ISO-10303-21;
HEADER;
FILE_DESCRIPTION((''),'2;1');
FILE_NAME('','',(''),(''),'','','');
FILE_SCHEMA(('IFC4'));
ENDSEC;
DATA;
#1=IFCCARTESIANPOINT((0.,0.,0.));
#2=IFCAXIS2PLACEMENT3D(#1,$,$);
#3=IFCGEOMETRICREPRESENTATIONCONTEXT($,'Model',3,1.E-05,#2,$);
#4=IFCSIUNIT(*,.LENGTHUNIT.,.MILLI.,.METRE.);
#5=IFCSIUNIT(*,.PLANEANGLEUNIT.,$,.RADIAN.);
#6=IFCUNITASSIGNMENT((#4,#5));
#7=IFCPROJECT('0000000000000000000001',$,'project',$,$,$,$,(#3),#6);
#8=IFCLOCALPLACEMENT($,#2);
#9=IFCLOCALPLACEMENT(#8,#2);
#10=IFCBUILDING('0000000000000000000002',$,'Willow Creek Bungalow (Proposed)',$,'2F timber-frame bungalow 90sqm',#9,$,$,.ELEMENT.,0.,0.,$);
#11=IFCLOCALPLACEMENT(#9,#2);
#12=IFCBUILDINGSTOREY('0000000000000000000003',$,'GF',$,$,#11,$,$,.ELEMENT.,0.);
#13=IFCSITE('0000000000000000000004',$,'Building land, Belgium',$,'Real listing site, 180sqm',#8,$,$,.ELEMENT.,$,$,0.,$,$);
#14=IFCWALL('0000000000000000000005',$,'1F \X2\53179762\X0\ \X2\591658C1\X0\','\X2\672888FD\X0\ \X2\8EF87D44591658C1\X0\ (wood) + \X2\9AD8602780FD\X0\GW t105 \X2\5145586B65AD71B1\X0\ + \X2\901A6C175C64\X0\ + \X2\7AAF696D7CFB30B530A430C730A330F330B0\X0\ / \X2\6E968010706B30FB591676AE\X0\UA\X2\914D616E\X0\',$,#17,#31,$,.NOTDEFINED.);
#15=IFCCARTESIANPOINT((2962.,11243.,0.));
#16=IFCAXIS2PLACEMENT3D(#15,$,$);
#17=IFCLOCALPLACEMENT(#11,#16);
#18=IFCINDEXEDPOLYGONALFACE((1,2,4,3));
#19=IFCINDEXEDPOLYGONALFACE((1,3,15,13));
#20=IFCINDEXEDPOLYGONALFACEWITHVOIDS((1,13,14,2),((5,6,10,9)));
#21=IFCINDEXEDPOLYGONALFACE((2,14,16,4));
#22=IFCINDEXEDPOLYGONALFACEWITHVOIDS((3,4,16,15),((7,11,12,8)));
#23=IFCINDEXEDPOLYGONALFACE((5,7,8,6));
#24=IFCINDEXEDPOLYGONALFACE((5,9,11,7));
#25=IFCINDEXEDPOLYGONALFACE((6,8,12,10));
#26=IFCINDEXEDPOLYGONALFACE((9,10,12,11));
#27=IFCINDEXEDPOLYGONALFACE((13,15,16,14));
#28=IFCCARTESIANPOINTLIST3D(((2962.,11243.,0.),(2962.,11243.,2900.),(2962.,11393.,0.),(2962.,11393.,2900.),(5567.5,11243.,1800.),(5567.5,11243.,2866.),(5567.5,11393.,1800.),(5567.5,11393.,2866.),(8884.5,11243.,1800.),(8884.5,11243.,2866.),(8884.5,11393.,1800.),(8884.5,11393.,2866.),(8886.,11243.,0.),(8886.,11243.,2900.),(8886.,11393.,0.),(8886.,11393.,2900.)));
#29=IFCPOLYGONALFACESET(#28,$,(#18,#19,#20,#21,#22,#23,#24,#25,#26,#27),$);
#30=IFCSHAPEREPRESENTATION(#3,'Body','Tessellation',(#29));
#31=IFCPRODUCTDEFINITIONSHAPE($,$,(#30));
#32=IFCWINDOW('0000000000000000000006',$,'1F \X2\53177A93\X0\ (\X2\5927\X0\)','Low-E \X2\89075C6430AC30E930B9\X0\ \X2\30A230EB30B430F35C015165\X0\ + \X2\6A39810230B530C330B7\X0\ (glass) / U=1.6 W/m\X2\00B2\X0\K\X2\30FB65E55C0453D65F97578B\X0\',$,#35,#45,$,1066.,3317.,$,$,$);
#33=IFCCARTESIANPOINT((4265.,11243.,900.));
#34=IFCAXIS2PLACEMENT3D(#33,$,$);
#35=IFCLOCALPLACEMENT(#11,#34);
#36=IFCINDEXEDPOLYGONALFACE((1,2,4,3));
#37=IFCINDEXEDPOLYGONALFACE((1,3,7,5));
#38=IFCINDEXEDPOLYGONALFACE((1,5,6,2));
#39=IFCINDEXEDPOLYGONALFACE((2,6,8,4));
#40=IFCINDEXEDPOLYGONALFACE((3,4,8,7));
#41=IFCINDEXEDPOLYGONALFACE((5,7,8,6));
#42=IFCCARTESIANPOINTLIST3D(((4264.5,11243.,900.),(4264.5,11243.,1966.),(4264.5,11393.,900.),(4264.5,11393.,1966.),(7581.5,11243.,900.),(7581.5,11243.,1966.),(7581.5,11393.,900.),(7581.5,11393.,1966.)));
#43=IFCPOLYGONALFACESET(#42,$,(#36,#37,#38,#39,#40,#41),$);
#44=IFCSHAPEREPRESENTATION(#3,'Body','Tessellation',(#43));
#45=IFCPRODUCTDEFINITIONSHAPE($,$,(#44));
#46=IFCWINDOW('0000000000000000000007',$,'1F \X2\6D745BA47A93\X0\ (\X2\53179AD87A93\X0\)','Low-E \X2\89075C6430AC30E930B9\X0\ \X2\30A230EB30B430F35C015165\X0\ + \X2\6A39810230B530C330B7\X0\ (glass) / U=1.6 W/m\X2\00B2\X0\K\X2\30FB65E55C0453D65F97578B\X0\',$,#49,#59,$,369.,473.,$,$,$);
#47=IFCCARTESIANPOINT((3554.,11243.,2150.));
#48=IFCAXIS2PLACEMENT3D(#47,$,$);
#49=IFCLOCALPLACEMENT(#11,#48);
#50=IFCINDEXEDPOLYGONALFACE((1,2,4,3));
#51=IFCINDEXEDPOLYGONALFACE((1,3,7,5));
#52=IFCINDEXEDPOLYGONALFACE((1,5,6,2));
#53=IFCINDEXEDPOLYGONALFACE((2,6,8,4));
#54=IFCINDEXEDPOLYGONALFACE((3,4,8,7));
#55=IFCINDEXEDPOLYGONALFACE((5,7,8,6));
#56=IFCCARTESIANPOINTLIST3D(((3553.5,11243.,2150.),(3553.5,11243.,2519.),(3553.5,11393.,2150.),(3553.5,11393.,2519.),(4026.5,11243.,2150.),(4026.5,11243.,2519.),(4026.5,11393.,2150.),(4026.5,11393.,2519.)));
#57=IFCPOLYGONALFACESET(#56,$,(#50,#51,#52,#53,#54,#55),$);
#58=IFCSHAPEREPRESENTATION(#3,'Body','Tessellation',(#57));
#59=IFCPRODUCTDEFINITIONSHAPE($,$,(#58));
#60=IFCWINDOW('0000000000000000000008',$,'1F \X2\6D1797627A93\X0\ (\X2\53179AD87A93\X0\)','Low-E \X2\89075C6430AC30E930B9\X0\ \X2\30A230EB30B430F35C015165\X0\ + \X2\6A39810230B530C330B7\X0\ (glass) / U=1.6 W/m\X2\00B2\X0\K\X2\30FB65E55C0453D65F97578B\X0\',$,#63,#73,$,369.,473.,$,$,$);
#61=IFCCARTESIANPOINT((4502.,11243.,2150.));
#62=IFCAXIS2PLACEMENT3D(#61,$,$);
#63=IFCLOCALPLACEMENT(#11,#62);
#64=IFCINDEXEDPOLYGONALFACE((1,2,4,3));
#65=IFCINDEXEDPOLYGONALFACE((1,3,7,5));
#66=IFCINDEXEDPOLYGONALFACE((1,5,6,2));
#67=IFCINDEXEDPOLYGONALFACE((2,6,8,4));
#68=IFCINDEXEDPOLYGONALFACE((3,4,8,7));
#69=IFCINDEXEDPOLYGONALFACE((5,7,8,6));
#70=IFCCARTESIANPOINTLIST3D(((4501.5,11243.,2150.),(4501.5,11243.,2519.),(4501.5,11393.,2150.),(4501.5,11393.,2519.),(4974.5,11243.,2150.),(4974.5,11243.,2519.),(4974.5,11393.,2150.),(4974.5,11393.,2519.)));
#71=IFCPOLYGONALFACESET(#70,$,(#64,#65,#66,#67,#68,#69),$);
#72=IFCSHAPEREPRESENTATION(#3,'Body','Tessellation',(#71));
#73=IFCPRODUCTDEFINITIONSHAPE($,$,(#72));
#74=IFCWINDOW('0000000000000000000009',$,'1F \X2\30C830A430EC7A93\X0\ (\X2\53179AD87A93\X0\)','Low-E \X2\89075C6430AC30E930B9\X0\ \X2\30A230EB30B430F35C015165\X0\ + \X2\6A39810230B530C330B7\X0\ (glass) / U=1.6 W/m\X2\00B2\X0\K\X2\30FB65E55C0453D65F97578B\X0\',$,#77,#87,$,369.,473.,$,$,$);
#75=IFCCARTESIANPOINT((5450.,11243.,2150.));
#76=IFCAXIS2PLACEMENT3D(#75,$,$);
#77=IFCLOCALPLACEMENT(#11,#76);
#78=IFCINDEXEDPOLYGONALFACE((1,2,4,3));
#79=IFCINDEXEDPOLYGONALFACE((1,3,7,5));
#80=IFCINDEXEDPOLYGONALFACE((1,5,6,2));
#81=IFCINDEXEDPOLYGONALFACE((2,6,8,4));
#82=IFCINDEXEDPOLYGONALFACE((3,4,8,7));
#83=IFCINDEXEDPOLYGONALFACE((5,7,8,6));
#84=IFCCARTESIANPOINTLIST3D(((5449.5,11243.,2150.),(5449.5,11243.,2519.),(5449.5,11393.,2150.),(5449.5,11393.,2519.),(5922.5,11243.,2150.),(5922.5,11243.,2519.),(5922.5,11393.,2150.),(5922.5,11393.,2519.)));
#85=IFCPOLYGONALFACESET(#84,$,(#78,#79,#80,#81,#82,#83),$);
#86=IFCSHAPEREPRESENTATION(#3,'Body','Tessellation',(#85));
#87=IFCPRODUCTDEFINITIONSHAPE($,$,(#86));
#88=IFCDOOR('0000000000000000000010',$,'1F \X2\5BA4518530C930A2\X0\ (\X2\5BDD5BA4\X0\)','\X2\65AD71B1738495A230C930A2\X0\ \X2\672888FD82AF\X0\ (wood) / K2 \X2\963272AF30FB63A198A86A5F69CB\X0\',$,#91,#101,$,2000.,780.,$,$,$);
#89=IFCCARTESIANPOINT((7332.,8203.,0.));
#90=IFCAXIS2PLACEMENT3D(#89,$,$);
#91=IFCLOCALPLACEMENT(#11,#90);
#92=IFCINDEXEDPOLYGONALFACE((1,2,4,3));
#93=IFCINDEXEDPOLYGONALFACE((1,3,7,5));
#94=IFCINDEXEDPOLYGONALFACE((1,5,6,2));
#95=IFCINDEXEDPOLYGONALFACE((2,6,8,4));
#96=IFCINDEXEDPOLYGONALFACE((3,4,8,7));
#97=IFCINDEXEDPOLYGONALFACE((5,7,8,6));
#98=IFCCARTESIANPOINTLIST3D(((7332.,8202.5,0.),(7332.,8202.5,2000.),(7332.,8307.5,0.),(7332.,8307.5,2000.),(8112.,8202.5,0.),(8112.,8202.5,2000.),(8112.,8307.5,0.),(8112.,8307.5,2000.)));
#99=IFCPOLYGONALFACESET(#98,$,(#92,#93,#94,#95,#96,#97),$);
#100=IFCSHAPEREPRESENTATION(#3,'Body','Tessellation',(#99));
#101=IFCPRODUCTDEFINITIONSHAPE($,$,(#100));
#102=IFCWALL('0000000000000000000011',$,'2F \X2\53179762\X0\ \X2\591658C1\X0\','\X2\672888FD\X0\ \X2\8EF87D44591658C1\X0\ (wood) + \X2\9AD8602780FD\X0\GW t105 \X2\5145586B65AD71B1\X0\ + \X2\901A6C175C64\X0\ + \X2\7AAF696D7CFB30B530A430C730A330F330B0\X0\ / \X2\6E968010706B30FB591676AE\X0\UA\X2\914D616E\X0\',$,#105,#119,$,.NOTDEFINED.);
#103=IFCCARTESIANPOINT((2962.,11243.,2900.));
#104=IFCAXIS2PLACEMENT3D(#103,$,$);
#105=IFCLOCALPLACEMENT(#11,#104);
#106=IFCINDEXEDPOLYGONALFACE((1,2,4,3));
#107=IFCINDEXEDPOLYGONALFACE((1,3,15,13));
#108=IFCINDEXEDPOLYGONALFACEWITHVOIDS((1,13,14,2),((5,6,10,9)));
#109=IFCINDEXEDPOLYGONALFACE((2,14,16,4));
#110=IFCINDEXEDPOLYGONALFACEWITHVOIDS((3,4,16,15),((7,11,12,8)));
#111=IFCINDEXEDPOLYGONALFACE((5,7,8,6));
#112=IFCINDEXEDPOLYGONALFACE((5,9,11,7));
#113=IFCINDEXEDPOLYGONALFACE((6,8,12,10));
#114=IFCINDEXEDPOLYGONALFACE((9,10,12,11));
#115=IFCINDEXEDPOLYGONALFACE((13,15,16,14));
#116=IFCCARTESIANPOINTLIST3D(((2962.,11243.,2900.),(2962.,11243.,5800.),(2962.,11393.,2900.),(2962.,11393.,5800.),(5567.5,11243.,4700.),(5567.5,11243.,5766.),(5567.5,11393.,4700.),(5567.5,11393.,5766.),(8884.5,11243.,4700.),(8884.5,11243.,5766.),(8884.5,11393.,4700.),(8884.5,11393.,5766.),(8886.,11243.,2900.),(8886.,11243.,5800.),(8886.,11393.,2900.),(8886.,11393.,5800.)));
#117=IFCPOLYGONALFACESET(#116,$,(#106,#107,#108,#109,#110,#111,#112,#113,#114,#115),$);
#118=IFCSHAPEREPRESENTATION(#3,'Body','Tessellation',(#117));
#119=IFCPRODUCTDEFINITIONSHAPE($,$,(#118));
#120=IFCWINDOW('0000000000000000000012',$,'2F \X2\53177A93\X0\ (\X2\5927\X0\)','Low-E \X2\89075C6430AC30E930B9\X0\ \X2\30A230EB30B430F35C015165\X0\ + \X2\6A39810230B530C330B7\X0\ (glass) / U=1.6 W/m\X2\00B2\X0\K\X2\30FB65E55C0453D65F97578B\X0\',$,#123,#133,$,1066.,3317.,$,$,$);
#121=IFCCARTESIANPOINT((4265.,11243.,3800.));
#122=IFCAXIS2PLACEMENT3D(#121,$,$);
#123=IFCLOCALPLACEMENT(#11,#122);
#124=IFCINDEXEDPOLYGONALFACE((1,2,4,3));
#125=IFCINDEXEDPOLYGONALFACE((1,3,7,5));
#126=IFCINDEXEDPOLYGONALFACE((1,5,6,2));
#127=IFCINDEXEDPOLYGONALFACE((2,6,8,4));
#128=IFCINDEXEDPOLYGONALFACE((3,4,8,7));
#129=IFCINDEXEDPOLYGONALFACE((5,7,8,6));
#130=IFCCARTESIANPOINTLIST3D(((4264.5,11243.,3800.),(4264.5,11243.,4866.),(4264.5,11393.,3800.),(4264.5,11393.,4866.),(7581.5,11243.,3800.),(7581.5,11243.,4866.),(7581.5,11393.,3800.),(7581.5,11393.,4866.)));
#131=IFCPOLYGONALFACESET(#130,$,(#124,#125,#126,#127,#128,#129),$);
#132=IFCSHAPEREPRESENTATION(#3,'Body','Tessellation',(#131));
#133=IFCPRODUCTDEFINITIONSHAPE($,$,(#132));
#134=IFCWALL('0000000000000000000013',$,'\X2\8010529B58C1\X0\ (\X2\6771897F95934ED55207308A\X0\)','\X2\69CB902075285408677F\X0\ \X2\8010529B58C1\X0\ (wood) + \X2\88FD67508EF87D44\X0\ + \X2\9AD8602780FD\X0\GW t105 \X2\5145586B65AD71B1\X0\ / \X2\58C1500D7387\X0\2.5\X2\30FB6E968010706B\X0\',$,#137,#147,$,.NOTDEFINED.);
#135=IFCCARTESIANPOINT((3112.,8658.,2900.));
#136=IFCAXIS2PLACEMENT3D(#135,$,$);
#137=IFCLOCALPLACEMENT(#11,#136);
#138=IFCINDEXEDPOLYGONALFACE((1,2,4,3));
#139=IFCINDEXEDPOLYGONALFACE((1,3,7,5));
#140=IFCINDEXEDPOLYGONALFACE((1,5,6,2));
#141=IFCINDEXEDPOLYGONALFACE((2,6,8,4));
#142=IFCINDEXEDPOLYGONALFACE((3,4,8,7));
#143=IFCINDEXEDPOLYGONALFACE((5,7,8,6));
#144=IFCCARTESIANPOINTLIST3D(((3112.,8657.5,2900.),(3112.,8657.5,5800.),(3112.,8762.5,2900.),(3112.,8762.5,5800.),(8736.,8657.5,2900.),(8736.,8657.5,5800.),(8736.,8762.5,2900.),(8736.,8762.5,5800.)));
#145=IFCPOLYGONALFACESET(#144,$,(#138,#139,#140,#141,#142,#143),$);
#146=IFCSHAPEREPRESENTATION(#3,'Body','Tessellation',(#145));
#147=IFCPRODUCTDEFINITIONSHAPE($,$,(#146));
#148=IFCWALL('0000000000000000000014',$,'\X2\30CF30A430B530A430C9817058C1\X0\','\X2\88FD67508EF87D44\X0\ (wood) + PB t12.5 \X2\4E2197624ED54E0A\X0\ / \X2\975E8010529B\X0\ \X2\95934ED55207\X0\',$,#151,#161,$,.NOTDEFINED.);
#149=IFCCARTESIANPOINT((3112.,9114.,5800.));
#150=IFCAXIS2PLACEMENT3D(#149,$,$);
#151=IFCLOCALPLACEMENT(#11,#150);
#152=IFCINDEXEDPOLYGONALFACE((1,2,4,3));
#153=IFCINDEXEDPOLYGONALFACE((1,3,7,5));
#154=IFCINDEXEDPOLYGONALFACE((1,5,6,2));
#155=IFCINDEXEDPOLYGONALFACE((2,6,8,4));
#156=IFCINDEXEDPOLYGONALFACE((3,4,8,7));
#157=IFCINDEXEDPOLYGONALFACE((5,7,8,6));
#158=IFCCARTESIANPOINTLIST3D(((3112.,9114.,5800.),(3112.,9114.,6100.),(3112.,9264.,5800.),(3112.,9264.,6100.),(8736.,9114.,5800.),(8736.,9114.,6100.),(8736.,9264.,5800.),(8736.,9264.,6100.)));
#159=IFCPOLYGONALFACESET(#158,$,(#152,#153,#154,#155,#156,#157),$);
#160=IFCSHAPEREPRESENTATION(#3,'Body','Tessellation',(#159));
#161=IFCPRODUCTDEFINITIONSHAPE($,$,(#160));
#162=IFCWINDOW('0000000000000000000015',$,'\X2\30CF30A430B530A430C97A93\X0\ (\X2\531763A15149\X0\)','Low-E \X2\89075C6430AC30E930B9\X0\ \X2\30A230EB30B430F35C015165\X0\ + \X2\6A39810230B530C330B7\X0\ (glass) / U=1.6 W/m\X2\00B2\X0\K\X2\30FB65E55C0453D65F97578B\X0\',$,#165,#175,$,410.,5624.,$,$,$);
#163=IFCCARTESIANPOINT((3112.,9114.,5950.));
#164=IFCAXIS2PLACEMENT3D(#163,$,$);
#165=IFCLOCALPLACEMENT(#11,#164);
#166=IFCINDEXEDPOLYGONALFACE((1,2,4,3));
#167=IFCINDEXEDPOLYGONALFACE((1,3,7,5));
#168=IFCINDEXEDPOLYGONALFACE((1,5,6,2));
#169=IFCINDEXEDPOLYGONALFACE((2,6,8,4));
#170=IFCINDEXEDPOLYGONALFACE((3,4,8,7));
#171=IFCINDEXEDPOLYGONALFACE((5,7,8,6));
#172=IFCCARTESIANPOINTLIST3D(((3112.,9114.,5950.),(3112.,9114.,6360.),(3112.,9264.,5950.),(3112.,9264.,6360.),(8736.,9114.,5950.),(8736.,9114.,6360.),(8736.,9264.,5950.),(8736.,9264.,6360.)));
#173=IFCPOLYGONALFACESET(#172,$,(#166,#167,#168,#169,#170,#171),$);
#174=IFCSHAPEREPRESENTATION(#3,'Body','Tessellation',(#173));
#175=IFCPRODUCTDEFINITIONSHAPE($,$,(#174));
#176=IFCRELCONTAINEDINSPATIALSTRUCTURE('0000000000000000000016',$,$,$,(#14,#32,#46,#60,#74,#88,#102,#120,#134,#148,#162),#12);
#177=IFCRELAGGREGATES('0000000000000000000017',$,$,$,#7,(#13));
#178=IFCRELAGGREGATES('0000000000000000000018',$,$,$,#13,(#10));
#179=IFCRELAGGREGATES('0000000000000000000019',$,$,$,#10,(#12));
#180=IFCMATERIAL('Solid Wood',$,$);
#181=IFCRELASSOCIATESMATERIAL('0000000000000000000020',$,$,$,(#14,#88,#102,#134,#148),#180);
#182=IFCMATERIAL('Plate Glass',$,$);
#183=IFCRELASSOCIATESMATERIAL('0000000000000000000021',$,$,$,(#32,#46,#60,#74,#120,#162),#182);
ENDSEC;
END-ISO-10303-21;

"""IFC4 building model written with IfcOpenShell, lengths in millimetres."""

from ifc_helpers import new_model, si_unit, frame, frame_2d, origin, place, context, project, spatial, rectangle, extrude, material, element, fill, save


model = new_model("IFC4")

# Units and contexts
model_context = context("Model", 3, precision=1e-05, world=origin())
ifc_project = project(units=[si_unit("LENGTHUNIT", "METRE", prefix="MILLI"), si_unit("PLANEANGLEUNIT", "RADIAN")], contexts=[model_context])

# Site, building, storey
site_placement = place(None, origin())
site = spatial("IfcSite", under=ifc_project, at=site_placement, Name="Building land, Belgium", ObjectType="Real listing site, 180sqm", CompositionType="ELEMENT", RefElevation=0.0)
building_placement = place(site_placement, origin())
building = spatial("IfcBuilding", under=site, at=building_placement, Name="Willow Creek Bungalow (Proposed)", ObjectType="2F timber-frame bungalow 90sqm", CompositionType="ELEMENT", ElevationOfRefHeight=0.0, ElevationOfTerrain=0.0)
storey_placement = place(building_placement, origin())
storey = spatial("IfcBuildingStorey", under=building, at=storey_placement, Name="GF", CompositionType="ELEMENT", Elevation=0.0)

# Wall, openings, windows
ifc_material_1 = material(Name="Solid Wood")
wall_1_placement = place(storey_placement, frame((2962.0, 11243.0, 0.0)))
wall_1 = element("IfcWall", 1, at=wall_1_placement, inside=storey, material=ifc_material_1, Name="1F 北面 外壁", Description="木製 軸組外壁 (wood) + 高性能GW t105 充填断熱 + 通気層 + 窯業系サイディング / 準耐火・外皮UA配慮", PredefinedType="NOTDEFINED", context=model_context, shape_type="SweptSolid", body=[
    extrude(rectangle(XDim=5924.0, YDim=150.0, at=frame_2d((2962.0, 75.0))), frame((2962.0, 11243.0, 0.0)), (0.0, 0.0, 1.0), 2900.0),
])
opening_1_placement = place(storey_placement, frame((4265.0, 11243.0, 900.0)))
opening_1 = element("IfcOpeningElement", 2, at=opening_1_placement, cuts=wall_1, PredefinedType="NOTDEFINED", context=model_context, shape_type="SweptSolid", body=[
    extrude(rectangle(XDim=3317.0, YDim=150.0, at=frame_2d((1658.0, 75.0))), frame((4265.0, 11243.0, 900.0)), (0.0, 0.0, 1.0), 1066.0),
])
opening_2_placement = place(storey_placement, frame((3554.0, 11243.0, 2150.0)))
opening_2 = element("IfcOpeningElement", 3, at=opening_2_placement, cuts=wall_1, PredefinedType="NOTDEFINED", context=model_context, shape_type="SweptSolid", body=[
    extrude(rectangle(XDim=473.0, YDim=150.0, at=frame_2d((236.0, 75.0))), frame((3554.0, 11243.0, 2150.0)), (0.0, 0.0, 1.0), 369.0),
])
opening_3_placement = place(storey_placement, frame((4502.0, 11243.0, 2150.0)))
opening_3 = element("IfcOpeningElement", 4, at=opening_3_placement, cuts=wall_1, PredefinedType="NOTDEFINED", context=model_context, shape_type="SweptSolid", body=[
    extrude(rectangle(XDim=473.0, YDim=150.0, at=frame_2d((236.0, 75.0))), frame((4502.0, 11243.0, 2150.0)), (0.0, 0.0, 1.0), 369.0),
])
opening_4_placement = place(storey_placement, frame((5450.0, 11243.0, 2150.0)))
opening_4 = element("IfcOpeningElement", 5, at=opening_4_placement, cuts=wall_1, PredefinedType="NOTDEFINED", context=model_context, shape_type="SweptSolid", body=[
    extrude(rectangle(XDim=473.0, YDim=150.0, at=frame_2d((236.0, 75.0))), frame((5450.0, 11243.0, 2150.0)), (0.0, 0.0, 1.0), 369.0),
])
ifc_material_2 = material(Name="Plate Glass")
window_1_placement = place(storey_placement, frame((4265.0, 11243.0, 900.0)))
window_1 = element("IfcWindow", 6, at=window_1_placement, inside=storey, material=ifc_material_2, Name="1F 北窓 (大)", Description="Low-E 複層ガラス アルゴン封入 + 樹脂サッシ (glass) / U=1.6 W/m²K・日射取得型", OverallHeight=1066.0, OverallWidth=3317.0, context=model_context, shape_type="SweptSolid", body=[
    extrude(rectangle(XDim=3317.0, YDim=150.0, at=frame_2d((1658.0, 75.0))), frame((4265.0, 11243.0, 900.0)), (0.0, 0.0, 1.0), 1066.0),
])
fill(opening_1, window_1)
window_2_placement = place(storey_placement, frame((3554.0, 11243.0, 2150.0)))
window_2 = element("IfcWindow", 7, at=window_2_placement, inside=storey, material=ifc_material_2, Name="1F 浴室窓 (北高窓)", Description="Low-E 複層ガラス アルゴン封入 + 樹脂サッシ (glass) / U=1.6 W/m²K・日射取得型", OverallHeight=369.0, OverallWidth=473.0, context=model_context, shape_type="SweptSolid", body=[
    extrude(rectangle(XDim=473.0, YDim=150.0, at=frame_2d((236.0, 75.0))), frame((3554.0, 11243.0, 2150.0)), (0.0, 0.0, 1.0), 369.0),
])
fill(opening_2, window_2)
window_3_placement = place(storey_placement, frame((4502.0, 11243.0, 2150.0)))
window_3 = element("IfcWindow", 8, at=window_3_placement, inside=storey, material=ifc_material_2, Name="1F 洗面窓 (北高窓)", Description="Low-E 複層ガラス アルゴン封入 + 樹脂サッシ (glass) / U=1.6 W/m²K・日射取得型", OverallHeight=369.0, OverallWidth=473.0, context=model_context, shape_type="SweptSolid", body=[
    extrude(rectangle(XDim=473.0, YDim=150.0, at=frame_2d((236.0, 75.0))), frame((4502.0, 11243.0, 2150.0)), (0.0, 0.0, 1.0), 369.0),
])
fill(opening_3, window_3)
window_4_placement = place(storey_placement, frame((5450.0, 11243.0, 2150.0)))
window_4 = element("IfcWindow", 9, at=window_4_placement, inside=storey, material=ifc_material_2, Name="1F トイレ窓 (北高窓)", Description="Low-E 複層ガラス アルゴン封入 + 樹脂サッシ (glass) / U=1.6 W/m²K・日射取得型", OverallHeight=369.0, OverallWidth=473.0, context=model_context, shape_type="SweptSolid", body=[
    extrude(rectangle(XDim=473.0, YDim=150.0, at=frame_2d((236.0, 75.0))), frame((5450.0, 11243.0, 2150.0)), (0.0, 0.0, 1.0), 369.0),
])
fill(opening_4, window_4)

# Door
door_1_placement = place(storey_placement, frame((7332.0, 8203.0, 0.0)))
element("IfcDoor", 10, at=door_1_placement, inside=storey, material=ifc_material_1, Name="1F 室内ドア (寝室)", Description="断熱玄関ドア 木製芯 (wood) / K2 防犯・採風機構", OverallHeight=2000.0, OverallWidth=780.0, context=model_context, shape_type="SweptSolid", body=[
    extrude(rectangle(XDim=780.0, YDim=105.0, at=frame_2d((390.0, 52.0))), frame((7332.0, 8203.0, 0.0)), (0.0, 0.0, 1.0), 2000.0),
])

# Wall, opening, window
wall_2_placement = place(storey_placement, frame((2962.0, 11243.0, 2900.0)))
wall_2 = element("IfcWall", 11, at=wall_2_placement, inside=storey, material=ifc_material_1, Name="2F 北面 外壁", Description="木製 軸組外壁 (wood) + 高性能GW t105 充填断熱 + 通気層 + 窯業系サイディング / 準耐火・外皮UA配慮", PredefinedType="NOTDEFINED", context=model_context, shape_type="SweptSolid", body=[
    extrude(rectangle(XDim=5924.0, YDim=150.0, at=frame_2d((2962.0, 75.0))), frame((2962.0, 11243.0, 2900.0)), (0.0, 0.0, 1.0), 2900.0),
])
opening_5_placement = place(storey_placement, frame((4265.0, 11243.0, 3800.0)))
opening_5 = element("IfcOpeningElement", 12, at=opening_5_placement, cuts=wall_2, PredefinedType="NOTDEFINED", context=model_context, shape_type="SweptSolid", body=[
    extrude(rectangle(XDim=3317.0, YDim=150.0, at=frame_2d((1658.0, 75.0))), frame((4265.0, 11243.0, 3800.0)), (0.0, 0.0, 1.0), 1066.0),
])
window_5_placement = place(storey_placement, frame((4265.0, 11243.0, 3800.0)))
window_5 = element("IfcWindow", 13, at=window_5_placement, inside=storey, material=ifc_material_2, Name="2F 北窓 (大)", Description="Low-E 複層ガラス アルゴン封入 + 樹脂サッシ (glass) / U=1.6 W/m²K・日射取得型", OverallHeight=1066.0, OverallWidth=3317.0, context=model_context, shape_type="SweptSolid", body=[
    extrude(rectangle(XDim=3317.0, YDim=150.0, at=frame_2d((1658.0, 75.0))), frame((4265.0, 11243.0, 3800.0)), (0.0, 0.0, 1.0), 1066.0),
])
fill(opening_5, window_5)

# Wall
wall_3_placement = place(storey_placement, frame((3112.0, 8658.0, 2900.0)))
element("IfcWall", 14, at=wall_3_placement, inside=storey, material=ifc_material_1, Name="耐力壁 (東西間仕切り)", Description="構造用合板 耐力壁 (wood) + 製材軸組 + 高性能GW t105 充填断熱 / 壁倍率2.5・準耐火", PredefinedType="NOTDEFINED", context=model_context, shape_type="SweptSolid", body=[
    extrude(rectangle(XDim=5624.0, YDim=105.0, at=frame_2d((2812.0, 52.0))), frame((3112.0, 8658.0, 2900.0)), (0.0, 0.0, 1.0), 2900.0),
])

# Wall, opening, window
wall_4_placement = place(storey_placement, frame((3112.0, 9114.0, 5800.0)))
wall_4 = element("IfcWall", 15, at=wall_4_placement, inside=storey, material=ifc_material_1, Name="ハイサイド腰壁", Description="製材軸組 (wood) + PB t12.5 両面仕上 / 非耐力 間仕切", PredefinedType="NOTDEFINED", context=model_context, shape_type="SweptSolid", body=[
    extrude(rectangle(XDim=5624.0, YDim=150.0, at=frame_2d((2812.0, 75.0))), frame((3112.0, 9114.0, 5800.0)), (0.0, 0.0, 1.0), 700.0),
])
opening_6_placement = place(storey_placement, frame((3112.0, 9114.0, 5950.0)))
opening_6 = element("IfcOpeningElement", 16, at=opening_6_placement, cuts=wall_4, PredefinedType="NOTDEFINED", context=model_context, shape_type="SweptSolid", body=[
    extrude(rectangle(XDim=5624.0, YDim=150.0, at=frame_2d((2812.0, 75.0))), frame((3112.0, 9114.0, 5950.0)), (0.0, 0.0, 1.0), 410.0),
])
window_6_placement = place(storey_placement, frame((3112.0, 9114.0, 5950.0)))
window_6 = element("IfcWindow", 17, at=window_6_placement, inside=storey, material=ifc_material_2, Name="ハイサイド窓 (北採光)", Description="Low-E 複層ガラス アルゴン封入 + 樹脂サッシ (glass) / U=1.6 W/m²K・日射取得型", OverallHeight=410.0, OverallWidth=5624.0, context=model_context, shape_type="SweptSolid", body=[
    extrude(rectangle(XDim=5624.0, YDim=150.0, at=frame_2d((2812.0, 75.0))), frame((3112.0, 9114.0, 5950.0)), (0.0, 0.0, 1.0), 410.0),
])
fill(opening_6, window_6)

save(model, "model.ifc")
